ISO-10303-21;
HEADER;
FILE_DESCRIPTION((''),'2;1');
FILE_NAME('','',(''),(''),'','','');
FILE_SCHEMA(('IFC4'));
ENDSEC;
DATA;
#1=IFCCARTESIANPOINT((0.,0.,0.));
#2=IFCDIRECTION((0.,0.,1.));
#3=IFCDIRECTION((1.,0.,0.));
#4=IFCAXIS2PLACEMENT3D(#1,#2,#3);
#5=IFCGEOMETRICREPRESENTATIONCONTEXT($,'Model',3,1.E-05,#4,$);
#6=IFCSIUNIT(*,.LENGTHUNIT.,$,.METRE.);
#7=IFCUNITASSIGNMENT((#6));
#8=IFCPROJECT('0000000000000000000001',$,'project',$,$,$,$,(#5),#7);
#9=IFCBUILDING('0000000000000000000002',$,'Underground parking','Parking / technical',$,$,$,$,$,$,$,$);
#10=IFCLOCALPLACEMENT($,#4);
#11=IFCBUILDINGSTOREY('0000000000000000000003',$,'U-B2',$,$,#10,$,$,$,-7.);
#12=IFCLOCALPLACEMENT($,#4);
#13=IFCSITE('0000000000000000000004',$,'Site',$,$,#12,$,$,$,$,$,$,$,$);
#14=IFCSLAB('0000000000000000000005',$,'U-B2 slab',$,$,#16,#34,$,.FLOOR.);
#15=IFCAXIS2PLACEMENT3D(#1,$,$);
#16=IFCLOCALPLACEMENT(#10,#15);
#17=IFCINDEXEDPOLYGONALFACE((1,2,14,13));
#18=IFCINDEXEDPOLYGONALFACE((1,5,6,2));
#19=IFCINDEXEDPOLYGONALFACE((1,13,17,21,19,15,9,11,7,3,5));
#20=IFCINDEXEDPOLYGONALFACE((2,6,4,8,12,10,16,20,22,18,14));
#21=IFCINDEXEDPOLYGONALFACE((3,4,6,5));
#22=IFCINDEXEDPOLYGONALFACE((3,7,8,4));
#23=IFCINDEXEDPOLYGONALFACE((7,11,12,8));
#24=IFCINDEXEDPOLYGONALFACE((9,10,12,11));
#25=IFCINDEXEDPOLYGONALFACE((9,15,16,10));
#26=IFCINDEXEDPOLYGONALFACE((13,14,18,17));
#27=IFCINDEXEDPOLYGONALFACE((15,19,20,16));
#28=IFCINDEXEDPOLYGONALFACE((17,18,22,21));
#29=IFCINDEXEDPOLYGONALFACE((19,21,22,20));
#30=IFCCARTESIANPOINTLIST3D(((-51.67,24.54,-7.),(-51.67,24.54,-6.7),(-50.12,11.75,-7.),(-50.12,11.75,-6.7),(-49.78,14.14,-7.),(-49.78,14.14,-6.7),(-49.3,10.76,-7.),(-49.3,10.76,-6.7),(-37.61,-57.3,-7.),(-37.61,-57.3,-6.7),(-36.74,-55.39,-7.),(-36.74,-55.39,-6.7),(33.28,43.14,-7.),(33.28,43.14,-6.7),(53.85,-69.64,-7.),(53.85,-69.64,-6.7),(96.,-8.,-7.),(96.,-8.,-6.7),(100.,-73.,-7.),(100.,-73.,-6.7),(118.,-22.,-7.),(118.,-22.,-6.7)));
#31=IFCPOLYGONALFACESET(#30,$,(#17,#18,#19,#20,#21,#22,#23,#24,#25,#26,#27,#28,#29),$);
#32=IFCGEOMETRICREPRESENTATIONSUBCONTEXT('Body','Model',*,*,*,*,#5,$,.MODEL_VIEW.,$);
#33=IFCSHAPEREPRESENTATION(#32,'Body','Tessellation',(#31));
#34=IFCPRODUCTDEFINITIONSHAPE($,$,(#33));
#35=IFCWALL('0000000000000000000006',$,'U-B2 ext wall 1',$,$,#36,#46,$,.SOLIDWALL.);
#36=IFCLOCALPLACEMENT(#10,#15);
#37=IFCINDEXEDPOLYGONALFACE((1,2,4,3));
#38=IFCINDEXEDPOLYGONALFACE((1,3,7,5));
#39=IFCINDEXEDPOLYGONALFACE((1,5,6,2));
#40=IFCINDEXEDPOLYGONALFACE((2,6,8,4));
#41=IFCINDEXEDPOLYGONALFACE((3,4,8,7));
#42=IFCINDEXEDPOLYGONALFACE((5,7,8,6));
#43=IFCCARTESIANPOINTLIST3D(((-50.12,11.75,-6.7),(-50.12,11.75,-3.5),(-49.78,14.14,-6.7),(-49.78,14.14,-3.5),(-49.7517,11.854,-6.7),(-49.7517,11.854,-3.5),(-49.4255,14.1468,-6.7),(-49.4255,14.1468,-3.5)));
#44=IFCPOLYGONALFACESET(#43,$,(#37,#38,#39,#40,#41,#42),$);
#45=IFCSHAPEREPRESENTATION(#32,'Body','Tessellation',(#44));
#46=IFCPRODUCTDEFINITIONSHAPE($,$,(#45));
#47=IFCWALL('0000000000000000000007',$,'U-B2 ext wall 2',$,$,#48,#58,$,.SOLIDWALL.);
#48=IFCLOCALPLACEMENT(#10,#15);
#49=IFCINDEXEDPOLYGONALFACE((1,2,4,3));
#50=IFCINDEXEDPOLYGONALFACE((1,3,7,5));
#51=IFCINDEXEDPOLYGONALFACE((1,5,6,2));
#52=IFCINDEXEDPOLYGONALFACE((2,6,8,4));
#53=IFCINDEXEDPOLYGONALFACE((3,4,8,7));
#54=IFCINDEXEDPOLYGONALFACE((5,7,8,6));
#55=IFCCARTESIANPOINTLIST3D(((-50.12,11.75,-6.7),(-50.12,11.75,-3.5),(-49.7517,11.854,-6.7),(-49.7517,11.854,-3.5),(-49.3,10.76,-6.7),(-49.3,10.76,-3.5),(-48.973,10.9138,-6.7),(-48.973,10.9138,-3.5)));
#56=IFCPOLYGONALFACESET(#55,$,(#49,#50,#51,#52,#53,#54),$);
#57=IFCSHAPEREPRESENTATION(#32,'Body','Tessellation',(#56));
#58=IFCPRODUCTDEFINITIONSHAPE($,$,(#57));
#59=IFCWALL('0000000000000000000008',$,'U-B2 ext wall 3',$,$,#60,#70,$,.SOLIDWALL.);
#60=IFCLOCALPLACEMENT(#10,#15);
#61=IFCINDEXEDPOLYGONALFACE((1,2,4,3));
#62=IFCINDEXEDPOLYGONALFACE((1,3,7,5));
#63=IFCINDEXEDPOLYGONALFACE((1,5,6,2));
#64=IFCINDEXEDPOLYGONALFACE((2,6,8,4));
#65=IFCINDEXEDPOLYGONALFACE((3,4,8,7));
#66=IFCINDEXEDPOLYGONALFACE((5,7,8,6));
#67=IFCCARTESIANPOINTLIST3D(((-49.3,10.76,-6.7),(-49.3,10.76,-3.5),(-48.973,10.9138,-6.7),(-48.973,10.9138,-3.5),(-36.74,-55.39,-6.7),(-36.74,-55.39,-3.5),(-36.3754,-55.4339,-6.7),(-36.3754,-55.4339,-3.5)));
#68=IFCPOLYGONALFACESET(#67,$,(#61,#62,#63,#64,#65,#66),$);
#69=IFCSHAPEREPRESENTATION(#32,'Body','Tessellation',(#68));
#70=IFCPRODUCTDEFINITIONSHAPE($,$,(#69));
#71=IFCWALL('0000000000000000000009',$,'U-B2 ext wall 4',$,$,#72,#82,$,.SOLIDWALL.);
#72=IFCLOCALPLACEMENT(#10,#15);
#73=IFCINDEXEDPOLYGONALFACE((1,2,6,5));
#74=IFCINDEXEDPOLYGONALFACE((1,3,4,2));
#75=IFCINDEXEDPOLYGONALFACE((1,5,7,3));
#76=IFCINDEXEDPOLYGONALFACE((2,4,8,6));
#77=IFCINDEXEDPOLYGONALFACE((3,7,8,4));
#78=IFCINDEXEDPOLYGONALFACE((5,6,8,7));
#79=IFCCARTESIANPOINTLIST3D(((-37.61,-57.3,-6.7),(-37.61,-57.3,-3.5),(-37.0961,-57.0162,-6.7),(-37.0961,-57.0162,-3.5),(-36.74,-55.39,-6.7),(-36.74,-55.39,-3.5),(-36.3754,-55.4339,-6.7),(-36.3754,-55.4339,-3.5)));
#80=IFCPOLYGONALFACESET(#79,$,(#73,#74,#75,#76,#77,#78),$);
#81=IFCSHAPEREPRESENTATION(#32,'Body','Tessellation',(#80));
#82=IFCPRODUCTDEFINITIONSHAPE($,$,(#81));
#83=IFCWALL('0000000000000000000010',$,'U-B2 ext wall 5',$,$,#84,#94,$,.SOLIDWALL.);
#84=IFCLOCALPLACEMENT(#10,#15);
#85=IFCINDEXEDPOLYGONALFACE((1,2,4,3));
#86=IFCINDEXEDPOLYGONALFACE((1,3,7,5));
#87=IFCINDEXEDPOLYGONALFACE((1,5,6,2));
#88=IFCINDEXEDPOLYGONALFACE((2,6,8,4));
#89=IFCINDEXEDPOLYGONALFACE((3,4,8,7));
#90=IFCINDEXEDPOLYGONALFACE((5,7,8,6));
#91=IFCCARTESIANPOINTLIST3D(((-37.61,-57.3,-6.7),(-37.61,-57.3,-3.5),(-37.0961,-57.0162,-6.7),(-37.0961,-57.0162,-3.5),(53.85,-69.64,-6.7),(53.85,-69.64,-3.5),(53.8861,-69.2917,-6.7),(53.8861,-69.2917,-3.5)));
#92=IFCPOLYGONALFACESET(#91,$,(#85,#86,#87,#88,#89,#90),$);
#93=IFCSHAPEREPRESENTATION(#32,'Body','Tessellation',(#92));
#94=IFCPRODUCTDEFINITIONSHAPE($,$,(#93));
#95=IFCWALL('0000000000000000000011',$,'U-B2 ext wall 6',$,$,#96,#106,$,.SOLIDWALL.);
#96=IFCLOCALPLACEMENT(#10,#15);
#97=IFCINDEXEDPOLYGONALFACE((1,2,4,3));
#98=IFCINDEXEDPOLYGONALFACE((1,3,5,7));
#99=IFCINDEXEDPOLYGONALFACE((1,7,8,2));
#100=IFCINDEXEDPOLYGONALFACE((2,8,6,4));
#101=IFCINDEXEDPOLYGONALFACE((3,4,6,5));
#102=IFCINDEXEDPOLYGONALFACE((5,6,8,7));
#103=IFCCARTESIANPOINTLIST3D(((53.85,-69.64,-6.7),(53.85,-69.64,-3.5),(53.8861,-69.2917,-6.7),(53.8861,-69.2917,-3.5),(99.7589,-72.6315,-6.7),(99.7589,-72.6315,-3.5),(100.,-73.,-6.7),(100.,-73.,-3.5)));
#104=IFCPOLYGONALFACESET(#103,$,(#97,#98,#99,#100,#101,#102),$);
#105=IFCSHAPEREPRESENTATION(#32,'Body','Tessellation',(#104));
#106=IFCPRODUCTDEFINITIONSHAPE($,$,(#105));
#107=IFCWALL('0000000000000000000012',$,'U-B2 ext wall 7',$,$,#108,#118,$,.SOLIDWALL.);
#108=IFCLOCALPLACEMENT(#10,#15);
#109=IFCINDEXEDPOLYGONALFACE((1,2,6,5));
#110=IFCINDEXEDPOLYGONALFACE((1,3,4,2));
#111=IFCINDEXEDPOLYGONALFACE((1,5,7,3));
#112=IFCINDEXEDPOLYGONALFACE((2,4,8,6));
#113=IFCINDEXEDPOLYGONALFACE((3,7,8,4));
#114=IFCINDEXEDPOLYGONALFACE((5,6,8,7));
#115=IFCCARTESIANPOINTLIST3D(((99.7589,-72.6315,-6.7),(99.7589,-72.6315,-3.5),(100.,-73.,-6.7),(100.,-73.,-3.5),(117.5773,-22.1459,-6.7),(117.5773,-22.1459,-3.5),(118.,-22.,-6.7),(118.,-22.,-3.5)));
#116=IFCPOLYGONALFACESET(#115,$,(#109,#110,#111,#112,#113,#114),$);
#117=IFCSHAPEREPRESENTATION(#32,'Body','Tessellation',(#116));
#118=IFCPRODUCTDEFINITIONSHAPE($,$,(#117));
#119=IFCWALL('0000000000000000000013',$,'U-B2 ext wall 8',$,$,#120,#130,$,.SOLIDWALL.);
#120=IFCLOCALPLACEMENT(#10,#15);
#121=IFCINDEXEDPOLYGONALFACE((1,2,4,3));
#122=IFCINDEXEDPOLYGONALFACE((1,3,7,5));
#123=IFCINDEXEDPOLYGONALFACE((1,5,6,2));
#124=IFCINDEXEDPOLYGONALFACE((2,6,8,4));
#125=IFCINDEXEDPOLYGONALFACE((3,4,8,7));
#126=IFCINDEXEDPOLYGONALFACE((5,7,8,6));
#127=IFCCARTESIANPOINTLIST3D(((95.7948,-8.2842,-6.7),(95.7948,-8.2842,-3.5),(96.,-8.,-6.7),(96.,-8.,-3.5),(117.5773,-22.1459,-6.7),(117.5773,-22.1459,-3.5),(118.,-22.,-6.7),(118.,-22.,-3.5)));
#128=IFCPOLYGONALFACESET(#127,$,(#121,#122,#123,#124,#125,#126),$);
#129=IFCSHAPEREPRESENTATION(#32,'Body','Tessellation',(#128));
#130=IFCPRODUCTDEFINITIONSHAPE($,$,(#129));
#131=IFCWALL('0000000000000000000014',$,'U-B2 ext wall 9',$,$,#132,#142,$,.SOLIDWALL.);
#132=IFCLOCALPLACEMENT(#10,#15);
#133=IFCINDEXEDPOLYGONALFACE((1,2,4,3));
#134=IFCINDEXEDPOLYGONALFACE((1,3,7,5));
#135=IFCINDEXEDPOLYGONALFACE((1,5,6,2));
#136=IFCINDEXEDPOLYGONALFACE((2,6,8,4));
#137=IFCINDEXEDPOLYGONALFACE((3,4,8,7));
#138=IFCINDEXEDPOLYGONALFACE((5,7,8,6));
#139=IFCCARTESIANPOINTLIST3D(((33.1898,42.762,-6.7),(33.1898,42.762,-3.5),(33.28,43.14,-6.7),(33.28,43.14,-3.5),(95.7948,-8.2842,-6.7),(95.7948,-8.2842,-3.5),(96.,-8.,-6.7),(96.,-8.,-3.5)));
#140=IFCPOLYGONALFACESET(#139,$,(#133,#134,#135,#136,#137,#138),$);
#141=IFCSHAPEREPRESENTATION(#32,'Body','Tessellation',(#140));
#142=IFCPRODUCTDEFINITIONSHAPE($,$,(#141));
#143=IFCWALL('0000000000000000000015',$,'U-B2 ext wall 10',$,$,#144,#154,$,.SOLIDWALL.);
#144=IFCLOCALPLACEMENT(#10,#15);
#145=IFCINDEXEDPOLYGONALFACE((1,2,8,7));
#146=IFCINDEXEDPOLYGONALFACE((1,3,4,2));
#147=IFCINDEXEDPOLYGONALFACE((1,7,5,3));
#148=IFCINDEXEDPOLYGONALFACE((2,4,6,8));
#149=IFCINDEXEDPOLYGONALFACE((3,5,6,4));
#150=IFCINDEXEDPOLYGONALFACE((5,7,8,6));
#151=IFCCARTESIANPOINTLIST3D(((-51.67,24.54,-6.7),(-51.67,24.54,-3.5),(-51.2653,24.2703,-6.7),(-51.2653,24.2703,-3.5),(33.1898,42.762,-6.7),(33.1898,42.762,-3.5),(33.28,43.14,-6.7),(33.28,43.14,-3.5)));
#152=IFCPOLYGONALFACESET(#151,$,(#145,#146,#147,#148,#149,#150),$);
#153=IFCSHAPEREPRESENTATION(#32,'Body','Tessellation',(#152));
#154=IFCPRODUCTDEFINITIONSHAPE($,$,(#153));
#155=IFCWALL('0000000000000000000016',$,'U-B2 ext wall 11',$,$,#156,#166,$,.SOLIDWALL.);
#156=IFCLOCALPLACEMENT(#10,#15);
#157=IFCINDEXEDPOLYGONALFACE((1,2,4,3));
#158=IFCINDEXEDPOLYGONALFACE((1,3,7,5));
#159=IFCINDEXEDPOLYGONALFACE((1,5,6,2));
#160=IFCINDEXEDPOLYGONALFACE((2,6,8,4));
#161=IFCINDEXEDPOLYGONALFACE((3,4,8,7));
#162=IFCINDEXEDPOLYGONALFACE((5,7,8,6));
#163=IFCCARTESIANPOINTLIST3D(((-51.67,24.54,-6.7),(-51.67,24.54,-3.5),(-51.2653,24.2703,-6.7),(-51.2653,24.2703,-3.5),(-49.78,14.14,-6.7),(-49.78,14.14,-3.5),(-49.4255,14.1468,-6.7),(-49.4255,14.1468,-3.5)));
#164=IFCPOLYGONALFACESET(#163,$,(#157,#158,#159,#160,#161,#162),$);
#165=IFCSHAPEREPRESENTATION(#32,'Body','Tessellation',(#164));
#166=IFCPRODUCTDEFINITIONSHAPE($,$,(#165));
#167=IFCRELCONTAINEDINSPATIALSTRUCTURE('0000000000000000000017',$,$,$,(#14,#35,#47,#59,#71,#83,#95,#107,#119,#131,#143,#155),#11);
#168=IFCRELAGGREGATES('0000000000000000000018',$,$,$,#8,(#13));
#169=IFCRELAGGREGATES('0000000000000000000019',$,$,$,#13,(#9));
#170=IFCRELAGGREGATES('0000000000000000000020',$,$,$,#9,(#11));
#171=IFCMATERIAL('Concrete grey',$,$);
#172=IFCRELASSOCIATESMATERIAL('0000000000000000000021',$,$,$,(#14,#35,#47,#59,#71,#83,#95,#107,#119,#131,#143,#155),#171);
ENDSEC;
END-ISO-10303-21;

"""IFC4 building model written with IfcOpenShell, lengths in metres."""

from ifc_helpers import new_model, si_unit, frame, origin_with_axes, place, context, subcontext, project, spatial, polyline, outline, extrude, material, element, save


model = new_model("IFC4")

# Units and contexts
model_context = context("Model", 3, precision=1e-05, world=origin_with_axes())
body_context = subcontext(model_context, "Body", "Model", "MODEL_VIEW")
ifc_project = project(units=[si_unit("LENGTHUNIT", "METRE")], contexts=[model_context])

# Site, building, storey
site_placement = place(None, origin_with_axes())
site = spatial("IfcSite", under=ifc_project, at=site_placement, Name="Site")
building = spatial("IfcBuilding", under=site, Name="Underground parking", Description="Parking / technical")
storey_placement = place(None, origin_with_axes())
storey = spatial("IfcBuildingStorey", under=building, at=storey_placement, Name="U-B2", Elevation=-7.0)

# Slab
ifc_material = material(Name="Concrete grey")
slab_placement = place(storey_placement, origin_with_axes())
element("IfcSlab", 1, at=slab_placement, inside=storey, material=ifc_material, Name="U-B2 slab", PredefinedType="FLOOR", context=body_context, shape_type="SweptSolid", body=[
    extrude(outline(polyline([(-49.78, 14.14), (-50.12, 11.75), (-49.3, 10.76), (-36.74, -55.39), (-37.61, -57.3), (53.85, -69.64), (100.0, -73.0), (118.0, -22.0), (96.0, -8.0), (33.28, 43.14), (-51.67, 24.54), (-49.78, 14.14)])), frame((0.0, 0.0, -7.0), z_axis=(0.0, 0.0, 1.0), x_axis=(1.0, 0.0, 0.0)), (0.0, 0.0, 1.0), 0.3),
])

# Walls
wall_1_placement = place(storey_placement, origin_with_axes())
element("IfcWall", 2, at=wall_1_placement, inside=storey, material=ifc_material, Name="U-B2 ext wall 1", PredefinedType="SOLIDWALL", context=body_context, shape_type="SweptSolid", body=[
    extrude(outline(polyline([(-49.78, 14.14), (-50.12, 11.75), (-49.7517, 11.854), (-49.4255, 14.1468), (-49.78, 14.14)])), frame((0.0, 0.0, -6.7), z_axis=(0.0, 0.0, 1.0), x_axis=(1.0, 0.0, 0.0)), (0.0, 0.0, 1.0), 3.2),
])
wall_2_placement = place(storey_placement, origin_with_axes())
element("IfcWall", 3, at=wall_2_placement, inside=storey, material=ifc_material, Name="U-B2 ext wall 2", PredefinedType="SOLIDWALL", context=body_context, shape_type="SweptSolid", body=[
    extrude(outline(polyline([(-50.12, 11.75), (-49.3, 10.76), (-48.973, 10.9138), (-49.7517, 11.854), (-50.12, 11.75)])), frame((0.0, 0.0, -6.7), z_axis=(0.0, 0.0, 1.0), x_axis=(1.0, 0.0, 0.0)), (0.0, 0.0, 1.0), 3.2),
])
wall_3_placement = place(storey_placement, origin_with_axes())
element("IfcWall", 4, at=wall_3_placement, inside=storey, material=ifc_material, Name="U-B2 ext wall 3", PredefinedType="SOLIDWALL", context=body_context, shape_type="SweptSolid", body=[
    extrude(outline(polyline([(-49.3, 10.76), (-36.74, -55.39), (-36.3754, -55.4339), (-48.973, 10.9138), (-49.3, 10.76)])), frame((0.0, 0.0, -6.7), z_axis=(0.0, 0.0, 1.0), x_axis=(1.0, 0.0, 0.0)), (0.0, 0.0, 1.0), 3.2),
])
wall_4_placement = place(storey_placement, origin_with_axes())
element("IfcWall", 5, at=wall_4_placement, inside=storey, material=ifc_material, Name="U-B2 ext wall 4", PredefinedType="SOLIDWALL", context=body_context, shape_type="SweptSolid", body=[
    extrude(outline(polyline([(-36.74, -55.39), (-37.61, -57.3), (-37.0961, -57.0162), (-36.3754, -55.4339), (-36.74, -55.39)])), frame((0.0, 0.0, -6.7), z_axis=(0.0, 0.0, 1.0), x_axis=(1.0, 0.0, 0.0)), (0.0, 0.0, 1.0), 3.2),
])
wall_5_placement = place(storey_placement, origin_with_axes())
element("IfcWall", 6, at=wall_5_placement, inside=storey, material=ifc_material, Name="U-B2 ext wall 5", PredefinedType="SOLIDWALL", context=body_context, shape_type="SweptSolid", body=[
    extrude(outline(polyline([(-37.61, -57.3), (53.85, -69.64), (53.8861, -69.2917), (-37.0961, -57.0162), (-37.61, -57.3)])), frame((0.0, 0.0, -6.7), z_axis=(0.0, 0.0, 1.0), x_axis=(1.0, 0.0, 0.0)), (0.0, 0.0, 1.0), 3.2),
])
wall_6_placement = place(storey_placement, origin_with_axes())
element("IfcWall", 7, at=wall_6_placement, inside=storey, material=ifc_material, Name="U-B2 ext wall 6", PredefinedType="SOLIDWALL", context=body_context, shape_type="SweptSolid", body=[
    extrude(outline(polyline([(53.85, -69.64), (100.0, -73.0), (99.7589, -72.6315), (53.8861, -69.2917), (53.85, -69.64)])), frame((0.0, 0.0, -6.7), z_axis=(0.0, 0.0, 1.0), x_axis=(1.0, 0.0, 0.0)), (0.0, 0.0, 1.0), 3.2),
])
wall_7_placement = place(storey_placement, origin_with_axes())
element("IfcWall", 8, at=wall_7_placement, inside=storey, material=ifc_material, Name="U-B2 ext wall 7", PredefinedType="SOLIDWALL", context=body_context, shape_type="SweptSolid", body=[
    extrude(outline(polyline([(100.0, -73.0), (118.0, -22.0), (117.5773, -22.1459), (99.7589, -72.6315), (100.0, -73.0)])), frame((0.0, 0.0, -6.7), z_axis=(0.0, 0.0, 1.0), x_axis=(1.0, 0.0, 0.0)), (0.0, 0.0, 1.0), 3.2),
])
wall_8_placement = place(storey_placement, origin_with_axes())
element("IfcWall", 9, at=wall_8_placement, inside=storey, material=ifc_material, Name="U-B2 ext wall 8", PredefinedType="SOLIDWALL", context=body_context, shape_type="SweptSolid", body=[
    extrude(outline(polyline([(118.0, -22.0), (96.0, -8.0), (95.7948, -8.2842), (117.5773, -22.1459), (118.0, -22.0)])), frame((0.0, 0.0, -6.7), z_axis=(0.0, 0.0, 1.0), x_axis=(1.0, 0.0, 0.0)), (0.0, 0.0, 1.0), 3.2),
])
wall_9_placement = place(storey_placement, origin_with_axes())
element("IfcWall", 10, at=wall_9_placement, inside=storey, material=ifc_material, Name="U-B2 ext wall 9", PredefinedType="SOLIDWALL", context=body_context, shape_type="SweptSolid", body=[
    extrude(outline(polyline([(96.0, -8.0), (33.28, 43.14), (33.1898, 42.762), (95.7948, -8.2842), (96.0, -8.0)])), frame((0.0, 0.0, -6.7), z_axis=(0.0, 0.0, 1.0), x_axis=(1.0, 0.0, 0.0)), (0.0, 0.0, 1.0), 3.2),
])
wall_10_placement = place(storey_placement, origin_with_axes())
element("IfcWall", 11, at=wall_10_placement, inside=storey, material=ifc_material, Name="U-B2 ext wall 10", PredefinedType="SOLIDWALL", context=body_context, shape_type="SweptSolid", body=[
    extrude(outline(polyline([(33.28, 43.14), (-51.67, 24.54), (-51.2653, 24.2703), (33.1898, 42.762), (33.28, 43.14)])), frame((0.0, 0.0, -6.7), z_axis=(0.0, 0.0, 1.0), x_axis=(1.0, 0.0, 0.0)), (0.0, 0.0, 1.0), 3.2),
])
wall_11_placement = place(storey_placement, origin_with_axes())
element("IfcWall", 12, at=wall_11_placement, inside=storey, material=ifc_material, Name="U-B2 ext wall 11", PredefinedType="SOLIDWALL", context=body_context, shape_type="SweptSolid", body=[
    extrude(outline(polyline([(-51.67, 24.54), (-49.78, 14.14), (-49.4255, 14.1468), (-51.2653, 24.2703), (-51.67, 24.54)])), frame((0.0, 0.0, -6.7), z_axis=(0.0, 0.0, 1.0), x_axis=(1.0, 0.0, 0.0)), (0.0, 0.0, 1.0), 3.2),
])

save(model, "model.ifc")
